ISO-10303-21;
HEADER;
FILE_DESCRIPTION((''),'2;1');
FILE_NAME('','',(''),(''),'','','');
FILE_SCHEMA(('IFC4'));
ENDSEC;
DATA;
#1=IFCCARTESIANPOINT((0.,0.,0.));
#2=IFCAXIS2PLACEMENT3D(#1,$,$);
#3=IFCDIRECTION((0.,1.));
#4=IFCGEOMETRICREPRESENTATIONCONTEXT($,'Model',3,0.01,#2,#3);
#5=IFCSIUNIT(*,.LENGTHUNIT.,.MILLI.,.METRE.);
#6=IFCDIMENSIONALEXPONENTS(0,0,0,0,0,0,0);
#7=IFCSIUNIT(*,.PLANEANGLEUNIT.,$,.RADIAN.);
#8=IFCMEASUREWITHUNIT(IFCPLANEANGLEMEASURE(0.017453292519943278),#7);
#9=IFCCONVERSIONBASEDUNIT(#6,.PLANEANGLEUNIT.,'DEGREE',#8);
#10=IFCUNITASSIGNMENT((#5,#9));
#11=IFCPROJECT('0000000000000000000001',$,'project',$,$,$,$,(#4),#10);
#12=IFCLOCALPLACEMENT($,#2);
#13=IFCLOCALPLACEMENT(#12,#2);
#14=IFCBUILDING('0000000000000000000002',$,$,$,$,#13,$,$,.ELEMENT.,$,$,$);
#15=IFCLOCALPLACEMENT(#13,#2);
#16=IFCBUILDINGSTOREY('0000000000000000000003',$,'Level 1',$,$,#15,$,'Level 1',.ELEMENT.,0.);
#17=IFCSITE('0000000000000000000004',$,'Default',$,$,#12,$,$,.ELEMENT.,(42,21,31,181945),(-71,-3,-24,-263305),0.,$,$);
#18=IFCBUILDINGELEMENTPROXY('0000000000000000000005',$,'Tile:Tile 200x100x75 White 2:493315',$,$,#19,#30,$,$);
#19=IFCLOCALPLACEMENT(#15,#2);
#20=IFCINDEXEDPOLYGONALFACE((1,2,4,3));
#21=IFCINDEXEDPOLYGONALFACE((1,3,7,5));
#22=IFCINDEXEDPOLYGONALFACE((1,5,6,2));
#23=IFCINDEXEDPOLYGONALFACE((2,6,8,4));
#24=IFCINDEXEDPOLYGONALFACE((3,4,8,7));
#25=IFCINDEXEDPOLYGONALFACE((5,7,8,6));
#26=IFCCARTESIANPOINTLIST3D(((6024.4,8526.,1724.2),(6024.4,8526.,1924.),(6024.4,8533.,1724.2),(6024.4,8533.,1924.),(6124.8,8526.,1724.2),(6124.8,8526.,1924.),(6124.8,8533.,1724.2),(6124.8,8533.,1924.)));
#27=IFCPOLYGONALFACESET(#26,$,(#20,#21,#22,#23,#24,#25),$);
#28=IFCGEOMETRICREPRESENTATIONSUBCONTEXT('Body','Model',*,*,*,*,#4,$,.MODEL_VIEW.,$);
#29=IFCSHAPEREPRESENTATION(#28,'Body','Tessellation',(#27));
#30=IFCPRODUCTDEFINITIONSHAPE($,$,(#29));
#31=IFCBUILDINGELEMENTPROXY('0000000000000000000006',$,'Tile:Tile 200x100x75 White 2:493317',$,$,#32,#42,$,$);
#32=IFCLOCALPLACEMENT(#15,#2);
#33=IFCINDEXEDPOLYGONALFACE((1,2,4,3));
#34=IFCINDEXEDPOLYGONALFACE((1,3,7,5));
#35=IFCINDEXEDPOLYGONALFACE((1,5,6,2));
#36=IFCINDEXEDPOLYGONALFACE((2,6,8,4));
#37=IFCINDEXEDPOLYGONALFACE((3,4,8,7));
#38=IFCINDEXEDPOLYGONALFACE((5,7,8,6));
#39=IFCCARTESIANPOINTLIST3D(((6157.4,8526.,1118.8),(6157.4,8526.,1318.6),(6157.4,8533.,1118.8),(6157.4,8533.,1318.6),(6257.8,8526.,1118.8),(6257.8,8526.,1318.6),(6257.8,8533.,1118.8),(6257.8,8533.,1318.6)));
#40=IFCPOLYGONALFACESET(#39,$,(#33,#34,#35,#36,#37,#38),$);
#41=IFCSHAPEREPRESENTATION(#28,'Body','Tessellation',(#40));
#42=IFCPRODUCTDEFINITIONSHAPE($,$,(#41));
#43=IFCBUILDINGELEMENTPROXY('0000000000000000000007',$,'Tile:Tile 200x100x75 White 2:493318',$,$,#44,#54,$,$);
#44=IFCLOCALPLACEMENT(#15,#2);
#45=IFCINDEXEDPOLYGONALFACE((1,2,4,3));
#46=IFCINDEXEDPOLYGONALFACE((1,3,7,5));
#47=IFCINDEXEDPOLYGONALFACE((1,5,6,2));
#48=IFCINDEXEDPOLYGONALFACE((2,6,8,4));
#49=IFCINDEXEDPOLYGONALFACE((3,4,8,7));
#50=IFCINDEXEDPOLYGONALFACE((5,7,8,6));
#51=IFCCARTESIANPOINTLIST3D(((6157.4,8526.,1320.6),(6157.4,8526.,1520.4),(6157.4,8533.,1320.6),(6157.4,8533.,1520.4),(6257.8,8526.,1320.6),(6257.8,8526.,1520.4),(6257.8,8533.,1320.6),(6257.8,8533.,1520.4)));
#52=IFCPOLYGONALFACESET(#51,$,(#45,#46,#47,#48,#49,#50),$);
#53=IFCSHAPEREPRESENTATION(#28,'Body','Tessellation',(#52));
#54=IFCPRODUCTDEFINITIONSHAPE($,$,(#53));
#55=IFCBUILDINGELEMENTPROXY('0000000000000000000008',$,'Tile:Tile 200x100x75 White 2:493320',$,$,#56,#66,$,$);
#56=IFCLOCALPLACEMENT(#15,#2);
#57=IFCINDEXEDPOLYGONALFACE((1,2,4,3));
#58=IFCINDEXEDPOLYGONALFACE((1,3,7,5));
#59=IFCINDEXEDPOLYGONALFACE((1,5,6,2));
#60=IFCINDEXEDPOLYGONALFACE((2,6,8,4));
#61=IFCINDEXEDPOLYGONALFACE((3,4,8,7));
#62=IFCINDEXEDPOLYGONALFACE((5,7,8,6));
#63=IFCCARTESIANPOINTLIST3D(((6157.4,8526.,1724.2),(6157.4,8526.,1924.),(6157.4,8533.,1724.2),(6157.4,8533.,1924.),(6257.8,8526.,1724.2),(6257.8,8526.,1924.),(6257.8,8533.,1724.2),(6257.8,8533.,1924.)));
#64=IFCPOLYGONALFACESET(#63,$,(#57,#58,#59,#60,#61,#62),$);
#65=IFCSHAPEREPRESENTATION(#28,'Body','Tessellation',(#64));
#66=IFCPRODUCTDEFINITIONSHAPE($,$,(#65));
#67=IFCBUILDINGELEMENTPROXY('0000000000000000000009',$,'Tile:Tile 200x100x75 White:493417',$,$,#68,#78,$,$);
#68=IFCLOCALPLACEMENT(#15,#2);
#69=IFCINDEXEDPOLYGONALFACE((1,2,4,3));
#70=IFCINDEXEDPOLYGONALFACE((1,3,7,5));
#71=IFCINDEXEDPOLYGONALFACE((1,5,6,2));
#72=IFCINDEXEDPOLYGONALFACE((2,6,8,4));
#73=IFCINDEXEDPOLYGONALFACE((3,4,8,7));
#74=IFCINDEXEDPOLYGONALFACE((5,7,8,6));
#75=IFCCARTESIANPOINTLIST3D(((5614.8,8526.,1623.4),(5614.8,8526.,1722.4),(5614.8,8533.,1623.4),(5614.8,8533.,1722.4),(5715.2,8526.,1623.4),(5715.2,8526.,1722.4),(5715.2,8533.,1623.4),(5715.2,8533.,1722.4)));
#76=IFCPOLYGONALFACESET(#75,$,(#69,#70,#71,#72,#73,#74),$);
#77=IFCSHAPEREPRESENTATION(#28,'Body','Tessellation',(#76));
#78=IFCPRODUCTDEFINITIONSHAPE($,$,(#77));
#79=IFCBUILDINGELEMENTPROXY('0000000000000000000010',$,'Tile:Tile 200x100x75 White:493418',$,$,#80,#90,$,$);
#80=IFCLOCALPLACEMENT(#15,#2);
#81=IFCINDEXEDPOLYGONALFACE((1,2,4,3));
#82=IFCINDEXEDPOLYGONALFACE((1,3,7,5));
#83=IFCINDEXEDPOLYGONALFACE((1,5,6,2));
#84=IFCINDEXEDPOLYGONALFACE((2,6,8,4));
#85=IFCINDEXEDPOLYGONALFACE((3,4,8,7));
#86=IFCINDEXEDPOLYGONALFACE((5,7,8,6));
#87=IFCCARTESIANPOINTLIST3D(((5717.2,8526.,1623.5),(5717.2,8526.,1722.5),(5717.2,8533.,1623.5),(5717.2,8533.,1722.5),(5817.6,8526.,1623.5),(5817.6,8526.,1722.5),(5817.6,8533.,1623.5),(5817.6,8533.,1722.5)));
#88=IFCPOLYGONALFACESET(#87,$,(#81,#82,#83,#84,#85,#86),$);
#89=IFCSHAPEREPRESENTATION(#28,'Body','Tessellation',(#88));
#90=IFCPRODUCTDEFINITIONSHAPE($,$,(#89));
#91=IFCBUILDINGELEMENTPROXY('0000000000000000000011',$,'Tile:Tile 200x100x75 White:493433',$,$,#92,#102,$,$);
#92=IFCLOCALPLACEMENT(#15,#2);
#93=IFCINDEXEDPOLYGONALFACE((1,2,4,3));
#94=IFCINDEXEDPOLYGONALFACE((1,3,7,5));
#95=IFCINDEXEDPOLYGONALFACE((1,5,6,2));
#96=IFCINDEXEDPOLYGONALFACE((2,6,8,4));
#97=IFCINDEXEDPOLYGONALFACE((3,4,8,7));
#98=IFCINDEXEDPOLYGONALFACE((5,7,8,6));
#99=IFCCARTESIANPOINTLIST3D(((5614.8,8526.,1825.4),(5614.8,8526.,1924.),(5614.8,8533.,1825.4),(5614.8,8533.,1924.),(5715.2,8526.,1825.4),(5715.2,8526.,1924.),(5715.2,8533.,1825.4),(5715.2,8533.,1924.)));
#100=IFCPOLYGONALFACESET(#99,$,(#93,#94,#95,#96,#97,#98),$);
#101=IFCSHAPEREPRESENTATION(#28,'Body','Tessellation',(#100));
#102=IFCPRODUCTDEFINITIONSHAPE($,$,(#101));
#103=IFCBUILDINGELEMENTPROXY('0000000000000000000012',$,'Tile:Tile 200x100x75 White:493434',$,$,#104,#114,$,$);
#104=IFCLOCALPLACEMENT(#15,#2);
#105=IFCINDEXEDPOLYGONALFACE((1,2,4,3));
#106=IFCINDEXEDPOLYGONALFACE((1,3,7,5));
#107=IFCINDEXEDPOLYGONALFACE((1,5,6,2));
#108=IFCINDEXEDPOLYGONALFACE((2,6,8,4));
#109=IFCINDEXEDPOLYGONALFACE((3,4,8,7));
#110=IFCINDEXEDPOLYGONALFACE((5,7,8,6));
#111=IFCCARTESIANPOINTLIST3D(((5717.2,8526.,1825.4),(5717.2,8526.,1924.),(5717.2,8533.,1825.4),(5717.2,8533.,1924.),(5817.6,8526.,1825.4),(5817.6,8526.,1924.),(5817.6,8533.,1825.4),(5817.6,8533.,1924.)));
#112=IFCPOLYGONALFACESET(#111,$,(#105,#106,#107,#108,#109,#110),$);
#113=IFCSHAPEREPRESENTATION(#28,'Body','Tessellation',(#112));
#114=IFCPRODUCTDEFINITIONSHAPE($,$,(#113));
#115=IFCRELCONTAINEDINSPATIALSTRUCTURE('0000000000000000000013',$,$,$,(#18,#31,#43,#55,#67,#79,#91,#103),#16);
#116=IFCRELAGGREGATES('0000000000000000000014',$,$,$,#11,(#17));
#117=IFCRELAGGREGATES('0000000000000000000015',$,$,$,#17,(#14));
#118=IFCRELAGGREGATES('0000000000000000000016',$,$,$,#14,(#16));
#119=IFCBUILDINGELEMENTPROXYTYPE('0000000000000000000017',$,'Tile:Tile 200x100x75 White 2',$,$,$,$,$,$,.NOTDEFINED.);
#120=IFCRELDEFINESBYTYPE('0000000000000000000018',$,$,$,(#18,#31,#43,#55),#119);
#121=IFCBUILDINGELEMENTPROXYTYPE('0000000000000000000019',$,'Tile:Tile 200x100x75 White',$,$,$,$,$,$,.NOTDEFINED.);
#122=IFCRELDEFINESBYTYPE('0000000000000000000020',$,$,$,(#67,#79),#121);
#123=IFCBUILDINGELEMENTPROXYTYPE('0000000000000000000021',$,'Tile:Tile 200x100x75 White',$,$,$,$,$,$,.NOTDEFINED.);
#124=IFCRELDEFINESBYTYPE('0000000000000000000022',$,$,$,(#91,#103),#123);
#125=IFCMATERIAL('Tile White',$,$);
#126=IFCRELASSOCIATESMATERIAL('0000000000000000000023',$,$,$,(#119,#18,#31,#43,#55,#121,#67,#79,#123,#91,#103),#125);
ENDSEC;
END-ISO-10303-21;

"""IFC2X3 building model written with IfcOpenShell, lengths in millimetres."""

from ifc_helpers import new_model, entity, si_unit, converted_unit, direction, frame, frame_2d, origin, origin_2d_with_axis, place, context, subcontext, project, spatial, rectangle, extrude, source, transform, mapped, material, type_object, type_shapes, element, save


model = new_model("IFC2X3")

# Units and contexts
model_context = context("Model", 3, precision=0.01, world=origin(), true_north=direction((0.0, 1.0)))
body_context = subcontext(model_context, "Body", "Model", "MODEL_VIEW")
ifc_project = project(units=[si_unit("LENGTHUNIT", "METRE", prefix="MILLI"), converted_unit("PLANEANGLEUNIT", "DEGREE", entity("IfcPlaneAngleMeasure", 0.017453292519943278), si_unit("PLANEANGLEUNIT", "RADIAN"), dimensions=[0, 0, 0, 0, 0, 0, 0])], contexts=[model_context])

# Site, building, storey
site_placement = place(None, origin())
site = spatial("IfcSite", under=ifc_project, at=site_placement, Name="Default", CompositionType="ELEMENT", RefLatitude=(42, 21, 31, 181945), RefLongitude=(-71, -3, -24, -263305), RefElevation=0.0)
building_placement = place(site_placement, origin())
building = spatial("IfcBuilding", under=site, at=building_placement, CompositionType="ELEMENT")
storey_placement = place(building_placement, origin())
storey = spatial("IfcBuildingStorey", under=building, at=storey_placement, Name="Level 1", LongName="Level 1", CompositionType="ELEMENT", Elevation=0.0)

# Building element proxies
ifc_material_1 = material(Name="Tile White")
building_element_proxy_type_1 = type_object("IfcBuildingElementProxyType", Name="Tile:Tile 200x100x75 White 2", PredefinedType="NOTDEFINED", material=ifc_material_1)
shared_shape_1 = source(origin(), body_context, "Body", "SweptSolid", [
    extrude(rectangle(XDim=199.8, YDim=100.4, at=frame_2d((0.0, 0.0), x_axis=(1.0, 0.0))), frame((-50.2, -99.9, 0.0), z_axis=(0.0, 0.0, 1.0), x_axis=(0.0, -1.0, 0.0)), (0.0, 0.0, 1.0), 7.0),
])
type_shapes(building_element_proxy_type_1, [shared_shape_1])
for number, where, z_axis, x_axis, name in (
    (1, (6024.4, 8533.0, 1724.2), (0.0, -1.0, 0.0), (-1.0, 0.0, 0.0), "Tile:Tile 200x100x75 White 2:493315"),
    (2, (6257.8, 8533.0, 1318.6), (0.0, -1.0, 0.0), (1.0, 0.0, 0.0), "Tile:Tile 200x100x75 White 2:493317"),
    (3, (6257.8, 8533.0, 1520.4), (0.0, -1.0, 0.0), (1.0, 0.0, 0.0), "Tile:Tile 200x100x75 White 2:493318"),
    (4, (6257.8, 8533.0, 1924.0), (0.0, -1.0, 0.0), (1.0, 0.0, 0.0), "Tile:Tile 200x100x75 White 2:493320"),
):
    element("IfcBuildingElementProxy", number, at=place(storey_placement, frame(where, z_axis=z_axis, x_axis=x_axis)), inside=storey, type_object=building_element_proxy_type_1, material=ifc_material_1, Name=name, context=body_context, shape_type="MappedRepresentation", body=[
        mapped(shared_shape_1, transform((0.0, 0.0, 0.0), scale=1.0)),
    ])
building_element_proxy_type_2 = type_object("IfcBuildingElementProxyType", Name="Tile:Tile 200x100x75 White", PredefinedType="NOTDEFINED", material=ifc_material_1)
shared_shape_2 = source(origin(), body_context, "Body", "SweptSolid", [
    extrude(rectangle(XDim=99.0, YDim=100.4, at=origin_2d_with_axis()), frame((-50.2, -49.5, 0.0), z_axis=(0.0, 0.0, 1.0), x_axis=(0.0, -1.0, 0.0)), (0.0, 0.0, 1.0), 7.0),
])
type_shapes(building_element_proxy_type_2, [shared_shape_2])
for number, where, z_axis, x_axis, name in (
    (5, (5715.2, 8533.0, 1722.4), (0.0, -1.0, 0.0), (1.0, 0.0, 0.0), "Tile:Tile 200x100x75 White:493417"),
    (6, (5817.6, 8533.0, 1722.5), (0.0, -1.0, 0.0), (1.0, 0.0, 0.0), "Tile:Tile 200x100x75 White:493418"),
):
    element("IfcBuildingElementProxy", number, at=place(storey_placement, frame(where, z_axis=z_axis, x_axis=x_axis)), inside=storey, type_object=building_element_proxy_type_2, material=ifc_material_1, Name=name, context=body_context, shape_type="MappedRepresentation", body=[
        mapped(shared_shape_2, transform((0.0, 0.0, 0.0), scale=1.0)),
    ])
building_element_proxy_type_3 = type_object("IfcBuildingElementProxyType", Name="Tile:Tile 200x100x75 White", PredefinedType="NOTDEFINED", material=ifc_material_1)
shared_shape_3 = source(origin(), body_context, "Body", "SweptSolid", [
    extrude(rectangle(XDim=98.6, YDim=100.4, at=origin_2d_with_axis()), frame((-50.2, -49.3, 0.0), z_axis=(0.0, 0.0, 1.0), x_axis=(0.0, -1.0, 0.0)), (0.0, 0.0, 1.0), 7.0),
])
type_shapes(building_element_proxy_type_3, [shared_shape_3])
for number, where, z_axis, x_axis, name in (
    (7, (5715.2, 8533.0, 1924.0), (0.0, -1.0, 0.0), (1.0, 0.0, 0.0), "Tile:Tile 200x100x75 White:493433"),
    (8, (5817.6, 8533.0, 1924.0), (0.0, -1.0, 0.0), (1.0, 0.0, 0.0), "Tile:Tile 200x100x75 White:493434"),
):
    element("IfcBuildingElementProxy", number, at=place(storey_placement, frame(where, z_axis=z_axis, x_axis=x_axis)), inside=storey, type_object=building_element_proxy_type_3, material=ifc_material_1, Name=name, context=body_context, shape_type="MappedRepresentation", body=[
        mapped(shared_shape_3, transform((0.0, 0.0, 0.0), scale=1.0)),
    ])

save(model, "model.ifc")
